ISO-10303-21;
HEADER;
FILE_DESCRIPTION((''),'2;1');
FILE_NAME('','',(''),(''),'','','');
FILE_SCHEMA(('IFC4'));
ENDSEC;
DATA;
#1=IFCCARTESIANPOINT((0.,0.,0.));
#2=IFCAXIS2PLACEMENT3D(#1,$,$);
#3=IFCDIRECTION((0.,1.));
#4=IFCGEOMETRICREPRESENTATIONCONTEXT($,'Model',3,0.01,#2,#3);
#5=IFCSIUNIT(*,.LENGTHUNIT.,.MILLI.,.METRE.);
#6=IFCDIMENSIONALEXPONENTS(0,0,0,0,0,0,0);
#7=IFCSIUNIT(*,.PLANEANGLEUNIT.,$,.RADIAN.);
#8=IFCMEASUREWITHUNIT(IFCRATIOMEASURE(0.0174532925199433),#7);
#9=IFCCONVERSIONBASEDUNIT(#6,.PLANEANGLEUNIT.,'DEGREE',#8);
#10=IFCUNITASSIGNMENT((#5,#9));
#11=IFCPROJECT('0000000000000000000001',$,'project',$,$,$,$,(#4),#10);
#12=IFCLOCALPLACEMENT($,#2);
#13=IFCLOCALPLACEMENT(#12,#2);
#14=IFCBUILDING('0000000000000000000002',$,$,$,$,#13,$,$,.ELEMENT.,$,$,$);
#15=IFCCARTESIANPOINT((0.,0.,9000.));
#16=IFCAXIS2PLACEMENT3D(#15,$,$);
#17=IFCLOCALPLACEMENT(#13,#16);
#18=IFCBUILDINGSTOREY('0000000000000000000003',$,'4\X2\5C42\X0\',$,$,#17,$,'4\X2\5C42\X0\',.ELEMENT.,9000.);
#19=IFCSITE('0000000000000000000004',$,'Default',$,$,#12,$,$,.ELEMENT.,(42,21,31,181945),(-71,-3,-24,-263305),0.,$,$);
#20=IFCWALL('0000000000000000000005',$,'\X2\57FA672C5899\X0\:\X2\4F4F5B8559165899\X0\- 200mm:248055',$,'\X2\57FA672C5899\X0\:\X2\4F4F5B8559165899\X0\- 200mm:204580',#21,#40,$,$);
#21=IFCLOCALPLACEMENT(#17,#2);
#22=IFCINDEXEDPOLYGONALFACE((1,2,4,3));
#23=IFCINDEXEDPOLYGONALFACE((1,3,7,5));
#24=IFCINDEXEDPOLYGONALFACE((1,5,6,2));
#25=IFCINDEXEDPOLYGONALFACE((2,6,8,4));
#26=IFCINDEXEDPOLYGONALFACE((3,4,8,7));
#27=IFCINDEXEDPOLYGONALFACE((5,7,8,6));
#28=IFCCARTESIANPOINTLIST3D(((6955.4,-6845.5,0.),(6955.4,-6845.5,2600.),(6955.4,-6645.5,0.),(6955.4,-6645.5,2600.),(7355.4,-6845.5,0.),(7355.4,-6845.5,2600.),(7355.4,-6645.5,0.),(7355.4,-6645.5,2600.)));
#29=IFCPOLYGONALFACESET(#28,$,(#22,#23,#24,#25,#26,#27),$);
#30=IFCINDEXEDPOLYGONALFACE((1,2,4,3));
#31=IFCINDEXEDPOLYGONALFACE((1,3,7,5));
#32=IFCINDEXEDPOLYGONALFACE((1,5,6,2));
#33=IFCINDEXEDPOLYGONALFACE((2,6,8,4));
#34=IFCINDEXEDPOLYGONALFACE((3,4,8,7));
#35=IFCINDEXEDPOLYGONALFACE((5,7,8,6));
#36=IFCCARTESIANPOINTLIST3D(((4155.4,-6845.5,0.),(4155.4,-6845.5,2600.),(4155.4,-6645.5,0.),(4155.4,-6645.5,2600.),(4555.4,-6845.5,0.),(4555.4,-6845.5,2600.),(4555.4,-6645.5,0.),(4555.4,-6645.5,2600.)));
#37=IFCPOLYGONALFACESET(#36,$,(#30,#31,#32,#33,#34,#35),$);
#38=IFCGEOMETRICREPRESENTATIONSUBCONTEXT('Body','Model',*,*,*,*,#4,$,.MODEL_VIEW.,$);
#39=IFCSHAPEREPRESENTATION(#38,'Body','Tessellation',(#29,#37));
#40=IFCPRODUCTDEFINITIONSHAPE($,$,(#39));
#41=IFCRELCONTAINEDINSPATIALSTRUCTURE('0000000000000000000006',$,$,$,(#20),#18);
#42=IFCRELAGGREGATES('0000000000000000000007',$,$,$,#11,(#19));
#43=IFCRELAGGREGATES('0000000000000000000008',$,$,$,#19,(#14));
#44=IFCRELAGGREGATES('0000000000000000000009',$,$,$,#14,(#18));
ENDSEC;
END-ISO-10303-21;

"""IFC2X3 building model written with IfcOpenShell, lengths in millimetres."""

from ifc_helpers import new_model, entity, si_unit, converted_unit, direction, frame, frame_2d, origin, place, context, subcontext, project, spatial, rectangle, extrude, element, save


model = new_model("IFC2X3")

# Units and contexts
model_context = context("Model", 3, precision=0.01, world=origin(), true_north=direction((0.0, 1.0)))
body_context = subcontext(model_context, "Body", "Model", "MODEL_VIEW")
ifc_project = project(units=[si_unit("LENGTHUNIT", "METRE", prefix="MILLI"), converted_unit("PLANEANGLEUNIT", "DEGREE", entity("IfcRatioMeasure", 0.0174532925199433), si_unit("PLANEANGLEUNIT", "RADIAN"), dimensions=[0, 0, 0, 0, 0, 0, 0])], contexts=[model_context])

# Site, building, storey
site_placement = place(None, origin())
site = spatial("IfcSite", under=ifc_project, at=site_placement, Name="Default", CompositionType="ELEMENT", RefLatitude=(42, 21, 31, 181945), RefLongitude=(-71, -3, -24, -263305), RefElevation=0.0)
building_placement = place(site_placement, origin())
building = spatial("IfcBuilding", under=site, at=building_placement, CompositionType="ELEMENT")
storey_placement = place(building_placement, frame((0.0, 0.0, 9000.0)))
storey = spatial("IfcBuildingStorey", under=building, at=storey_placement, Name="4层", LongName="4层", CompositionType="ELEMENT", Elevation=9000.0)

# Wall, opening
wall_placement = place(storey_placement, frame((7355.4, -6745.5, 0.0), z_axis=(0.0, 0.0, 1.0), x_axis=(-1.0, 0.0, 0.0)))
wall = element("IfcWall", 1, at=wall_placement, inside=storey, Name="基本墙:住宅外墙- 200mm:248055", ObjectType="基本墙:住宅外墙- 200mm:204580", context=body_context, shape_type="SweptSolid", body=[
    extrude(rectangle(XDim=400.0, YDim=200.0, at=frame_2d((0.0, 0.0), x_axis=(1.0, 0.0))), frame((200.0, 0.0, 0.0), z_axis=(0.0, 0.0, 1.0), x_axis=(-1.0, 0.0, 0.0)), (0.0, 0.0, 1.0), 2600.0),
    extrude(rectangle(XDim=400.0, YDim=200.0, at=frame_2d((0.0, 0.0), x_axis=(1.0, 0.0))), frame((3000.0, 0.0, 0.0)), (0.0, 0.0, 1.0), 2600.0),
])
opening_placement = place(wall_placement, frame((400.0, -100.0, 0.0)))
element("IfcOpeningElement", 2, at=opening_placement, cuts=wall, ObjectType="Opening", context=body_context, shape_type="SweptSolid", body=[
    extrude(rectangle(XDim=2600.0, YDim=2400.0, at=frame_2d((1300.0, 1200.0), x_axis=(1.0, 0.0))), frame((0.0, 0.0, 0.0), z_axis=(0.0, 1.0, 0.0), x_axis=(0.0, 0.0, 1.0)), (0.0, 0.0, 1.0), 200.0),
])

save(model, "model.ifc")
